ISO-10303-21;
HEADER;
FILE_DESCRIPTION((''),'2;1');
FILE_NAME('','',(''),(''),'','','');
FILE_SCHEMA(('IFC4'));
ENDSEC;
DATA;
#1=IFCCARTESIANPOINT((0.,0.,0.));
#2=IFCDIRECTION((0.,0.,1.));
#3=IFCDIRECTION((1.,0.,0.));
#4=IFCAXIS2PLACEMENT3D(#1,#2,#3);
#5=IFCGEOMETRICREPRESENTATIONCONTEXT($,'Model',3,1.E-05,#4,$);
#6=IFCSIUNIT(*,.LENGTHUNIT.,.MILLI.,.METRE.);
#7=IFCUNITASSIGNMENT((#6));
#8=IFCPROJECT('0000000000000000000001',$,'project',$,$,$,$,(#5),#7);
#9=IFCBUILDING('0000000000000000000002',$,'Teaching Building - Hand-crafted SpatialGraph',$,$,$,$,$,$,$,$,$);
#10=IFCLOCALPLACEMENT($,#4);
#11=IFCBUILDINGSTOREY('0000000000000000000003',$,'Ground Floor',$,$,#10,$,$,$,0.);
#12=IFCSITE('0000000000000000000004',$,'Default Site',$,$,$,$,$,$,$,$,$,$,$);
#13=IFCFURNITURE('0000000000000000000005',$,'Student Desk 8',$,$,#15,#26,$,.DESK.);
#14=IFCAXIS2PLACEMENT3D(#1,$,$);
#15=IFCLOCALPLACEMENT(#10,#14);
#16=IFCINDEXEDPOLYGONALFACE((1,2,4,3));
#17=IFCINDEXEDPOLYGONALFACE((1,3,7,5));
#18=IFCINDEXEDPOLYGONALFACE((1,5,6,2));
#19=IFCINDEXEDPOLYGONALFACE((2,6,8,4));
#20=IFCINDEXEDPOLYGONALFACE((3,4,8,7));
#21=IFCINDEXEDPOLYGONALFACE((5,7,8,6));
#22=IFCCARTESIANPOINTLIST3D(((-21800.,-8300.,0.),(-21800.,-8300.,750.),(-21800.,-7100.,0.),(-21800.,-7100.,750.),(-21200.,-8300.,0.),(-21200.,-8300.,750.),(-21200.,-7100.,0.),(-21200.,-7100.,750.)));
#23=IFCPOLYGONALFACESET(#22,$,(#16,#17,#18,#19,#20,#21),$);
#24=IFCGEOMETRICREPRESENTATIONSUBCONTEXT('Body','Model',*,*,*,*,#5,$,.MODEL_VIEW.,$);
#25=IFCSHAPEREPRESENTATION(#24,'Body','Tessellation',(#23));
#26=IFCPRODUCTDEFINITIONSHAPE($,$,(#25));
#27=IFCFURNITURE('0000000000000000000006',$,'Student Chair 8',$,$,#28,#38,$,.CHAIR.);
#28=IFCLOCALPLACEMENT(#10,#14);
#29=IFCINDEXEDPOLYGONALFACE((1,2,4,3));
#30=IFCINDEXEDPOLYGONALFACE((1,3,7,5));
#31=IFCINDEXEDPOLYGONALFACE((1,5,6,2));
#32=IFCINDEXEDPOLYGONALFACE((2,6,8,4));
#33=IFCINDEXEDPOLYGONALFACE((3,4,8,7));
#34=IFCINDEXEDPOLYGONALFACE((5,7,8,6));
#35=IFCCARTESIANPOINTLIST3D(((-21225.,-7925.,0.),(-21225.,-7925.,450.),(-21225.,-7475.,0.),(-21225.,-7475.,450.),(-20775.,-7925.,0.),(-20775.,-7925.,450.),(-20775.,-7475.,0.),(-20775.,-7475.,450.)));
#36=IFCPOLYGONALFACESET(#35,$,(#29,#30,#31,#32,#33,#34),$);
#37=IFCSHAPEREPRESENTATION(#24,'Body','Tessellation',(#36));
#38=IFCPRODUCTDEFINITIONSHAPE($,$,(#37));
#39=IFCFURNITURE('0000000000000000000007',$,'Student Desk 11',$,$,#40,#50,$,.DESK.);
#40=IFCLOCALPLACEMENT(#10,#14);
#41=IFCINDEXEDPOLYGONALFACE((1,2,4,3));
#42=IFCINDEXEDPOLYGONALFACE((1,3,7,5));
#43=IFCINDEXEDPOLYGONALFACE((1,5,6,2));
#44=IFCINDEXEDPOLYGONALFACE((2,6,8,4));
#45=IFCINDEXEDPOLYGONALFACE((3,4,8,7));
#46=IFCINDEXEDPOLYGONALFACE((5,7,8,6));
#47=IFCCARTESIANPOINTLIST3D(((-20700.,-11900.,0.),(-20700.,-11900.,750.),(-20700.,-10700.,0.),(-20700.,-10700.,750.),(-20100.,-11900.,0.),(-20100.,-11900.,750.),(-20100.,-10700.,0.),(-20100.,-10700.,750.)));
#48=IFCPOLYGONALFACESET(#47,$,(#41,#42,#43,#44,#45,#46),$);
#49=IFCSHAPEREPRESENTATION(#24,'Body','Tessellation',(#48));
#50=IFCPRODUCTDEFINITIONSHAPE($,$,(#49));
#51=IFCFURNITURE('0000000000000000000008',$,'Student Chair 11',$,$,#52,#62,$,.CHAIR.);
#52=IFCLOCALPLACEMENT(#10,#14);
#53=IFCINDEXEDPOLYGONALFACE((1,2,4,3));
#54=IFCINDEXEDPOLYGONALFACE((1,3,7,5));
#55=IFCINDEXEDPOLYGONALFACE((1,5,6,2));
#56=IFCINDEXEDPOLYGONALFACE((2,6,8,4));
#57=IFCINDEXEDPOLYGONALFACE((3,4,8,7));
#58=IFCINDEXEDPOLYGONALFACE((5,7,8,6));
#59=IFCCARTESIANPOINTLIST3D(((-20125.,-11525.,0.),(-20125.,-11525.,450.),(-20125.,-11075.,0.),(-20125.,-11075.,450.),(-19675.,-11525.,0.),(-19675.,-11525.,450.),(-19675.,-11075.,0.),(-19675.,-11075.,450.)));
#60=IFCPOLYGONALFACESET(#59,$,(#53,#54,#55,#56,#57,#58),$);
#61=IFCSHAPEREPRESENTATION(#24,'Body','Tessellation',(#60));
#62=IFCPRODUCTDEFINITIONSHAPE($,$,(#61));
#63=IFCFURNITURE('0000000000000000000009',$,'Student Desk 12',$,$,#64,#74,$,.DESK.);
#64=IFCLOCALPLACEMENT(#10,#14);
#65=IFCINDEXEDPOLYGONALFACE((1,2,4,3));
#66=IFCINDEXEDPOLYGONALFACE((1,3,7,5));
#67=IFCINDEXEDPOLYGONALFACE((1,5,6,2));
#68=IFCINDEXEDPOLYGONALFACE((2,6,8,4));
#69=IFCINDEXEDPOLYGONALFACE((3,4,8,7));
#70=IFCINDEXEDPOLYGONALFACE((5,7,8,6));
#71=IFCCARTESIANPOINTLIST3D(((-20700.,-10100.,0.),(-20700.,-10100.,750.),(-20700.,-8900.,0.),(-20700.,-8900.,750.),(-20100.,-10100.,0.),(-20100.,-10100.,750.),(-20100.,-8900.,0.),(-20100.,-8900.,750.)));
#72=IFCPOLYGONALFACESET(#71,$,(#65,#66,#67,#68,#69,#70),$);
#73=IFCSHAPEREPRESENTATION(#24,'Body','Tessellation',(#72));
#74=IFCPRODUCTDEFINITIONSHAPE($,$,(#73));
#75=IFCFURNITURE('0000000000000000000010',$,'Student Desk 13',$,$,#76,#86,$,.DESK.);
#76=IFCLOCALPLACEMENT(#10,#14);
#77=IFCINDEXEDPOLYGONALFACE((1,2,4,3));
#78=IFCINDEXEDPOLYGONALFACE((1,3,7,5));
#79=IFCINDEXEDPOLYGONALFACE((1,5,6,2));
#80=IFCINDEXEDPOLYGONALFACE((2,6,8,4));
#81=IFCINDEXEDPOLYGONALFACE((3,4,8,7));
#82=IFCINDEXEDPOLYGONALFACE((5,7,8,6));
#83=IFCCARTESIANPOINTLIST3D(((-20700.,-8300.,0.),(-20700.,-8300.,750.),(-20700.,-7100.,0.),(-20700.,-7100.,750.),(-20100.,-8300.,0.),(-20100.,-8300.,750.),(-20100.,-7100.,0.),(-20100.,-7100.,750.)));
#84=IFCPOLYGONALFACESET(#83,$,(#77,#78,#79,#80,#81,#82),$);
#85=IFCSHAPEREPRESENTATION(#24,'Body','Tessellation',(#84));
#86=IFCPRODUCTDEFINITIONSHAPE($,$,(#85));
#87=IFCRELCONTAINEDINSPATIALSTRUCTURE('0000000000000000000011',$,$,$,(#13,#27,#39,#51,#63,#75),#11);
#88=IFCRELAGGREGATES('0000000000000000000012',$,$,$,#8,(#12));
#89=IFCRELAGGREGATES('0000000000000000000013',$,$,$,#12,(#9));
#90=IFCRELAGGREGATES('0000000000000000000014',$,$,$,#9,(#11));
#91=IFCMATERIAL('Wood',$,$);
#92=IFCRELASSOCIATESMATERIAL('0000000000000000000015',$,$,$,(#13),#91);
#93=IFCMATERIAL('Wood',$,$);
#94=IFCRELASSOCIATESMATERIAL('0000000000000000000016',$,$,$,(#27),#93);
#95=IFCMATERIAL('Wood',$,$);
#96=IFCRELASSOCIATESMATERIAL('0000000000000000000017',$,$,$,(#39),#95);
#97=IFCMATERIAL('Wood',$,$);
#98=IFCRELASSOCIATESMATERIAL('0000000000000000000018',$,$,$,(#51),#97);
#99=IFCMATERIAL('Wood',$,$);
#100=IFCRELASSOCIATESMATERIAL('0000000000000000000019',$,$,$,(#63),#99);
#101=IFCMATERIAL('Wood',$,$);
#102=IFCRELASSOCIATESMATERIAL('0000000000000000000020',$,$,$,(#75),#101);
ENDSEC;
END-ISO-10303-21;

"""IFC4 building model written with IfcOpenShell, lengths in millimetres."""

from ifc_helpers import new_model, si_unit, frame, origin_with_axes, origin_2d, place, context, subcontext, project, spatial, rectangle, extrude, material, element, save


model = new_model("IFC4")

# Units and contexts
model_context = context("Model", 3, precision=1e-05, world=origin_with_axes())
body_context = subcontext(model_context, "Body", "Model", "MODEL_VIEW")
ifc_project = project(units=[si_unit("LENGTHUNIT", "METRE", prefix="MILLI")], contexts=[model_context])

# Site, building, storey
site = spatial("IfcSite", under=ifc_project, Name="Default Site")
building = spatial("IfcBuilding", under=site, Name="Teaching Building - Hand-crafted SpatialGraph")
storey_placement = place(None, origin_with_axes())
storey = spatial("IfcBuildingStorey", under=building, at=storey_placement, Name="Ground Floor", Elevation=0.0)

# Furniture
ifc_material_1 = material(Name="Wood")
furniture_1_placement = place(storey_placement, frame((-21500.0, -7700.0, 0.0), z_axis=(0.0, 0.0, 1.0), x_axis=(0.0, 1.0, 0.0)))
element("IfcFurniture", 1, at=furniture_1_placement, inside=storey, material=ifc_material_1, Name="Student Desk 8", PredefinedType="DESK", context=body_context, shape_type="SweptSolid", body=[
    extrude(rectangle(XDim=1200.0, YDim=600.0, at=origin_2d()), origin_with_axes(), (0.0, 0.0, 1.0), 750.0),
])
ifc_material_2 = material(Name="Wood")
furniture_2_placement = place(storey_placement, frame((-21000.0, -7700.0, 0.0), z_axis=(0.0, 0.0, 1.0), x_axis=(1.0, 0.0, 0.0)))
element("IfcFurniture", 2, at=furniture_2_placement, inside=storey, material=ifc_material_2, Name="Student Chair 8", PredefinedType="CHAIR", context=body_context, shape_type="SweptSolid", body=[
    extrude(rectangle(XDim=450.0, YDim=450.0, at=origin_2d()), origin_with_axes(), (0.0, 0.0, 1.0), 450.0),
])
ifc_material_3 = material(Name="Wood")
furniture_3_placement = place(storey_placement, frame((-20400.0, -11300.0, 0.0), z_axis=(0.0, 0.0, 1.0), x_axis=(0.0, 1.0, 0.0)))
element("IfcFurniture", 3, at=furniture_3_placement, inside=storey, material=ifc_material_3, Name="Student Desk 11", PredefinedType="DESK", context=body_context, shape_type="SweptSolid", body=[
    extrude(rectangle(XDim=1200.0, YDim=600.0, at=origin_2d()), origin_with_axes(), (0.0, 0.0, 1.0), 750.0),
])
ifc_material_4 = material(Name="Wood")
furniture_4_placement = place(storey_placement, frame((-19900.0, -11300.0, 0.0), z_axis=(0.0, 0.0, 1.0), x_axis=(1.0, 0.0, 0.0)))
element("IfcFurniture", 4, at=furniture_4_placement, inside=storey, material=ifc_material_4, Name="Student Chair 11", PredefinedType="CHAIR", context=body_context, shape_type="SweptSolid", body=[
    extrude(rectangle(XDim=450.0, YDim=450.0, at=origin_2d()), origin_with_axes(), (0.0, 0.0, 1.0), 450.0),
])
ifc_material_5 = material(Name="Wood")
furniture_5_placement = place(storey_placement, frame((-20400.0, -9500.0, 0.0), z_axis=(0.0, 0.0, 1.0), x_axis=(0.0, 1.0, 0.0)))
element("IfcFurniture", 5, at=furniture_5_placement, inside=storey, material=ifc_material_5, Name="Student Desk 12", PredefinedType="DESK", context=body_context, shape_type="SweptSolid", body=[
    extrude(rectangle(XDim=1200.0, YDim=600.0, at=origin_2d()), origin_with_axes(), (0.0, 0.0, 1.0), 750.0),
])
ifc_material_6 = material(Name="Wood")
furniture_6_placement = place(storey_placement, frame((-20400.0, -7700.0, 0.0), z_axis=(0.0, 0.0, 1.0), x_axis=(0.0, 1.0, 0.0)))
element("IfcFurniture", 6, at=furniture_6_placement, inside=storey, material=ifc_material_6, Name="Student Desk 13", PredefinedType="DESK", context=body_context, shape_type="SweptSolid", body=[
    extrude(rectangle(XDim=1200.0, YDim=600.0, at=origin_2d()), origin_with_axes(), (0.0, 0.0, 1.0), 750.0),
])

save(model, "model.ifc")
